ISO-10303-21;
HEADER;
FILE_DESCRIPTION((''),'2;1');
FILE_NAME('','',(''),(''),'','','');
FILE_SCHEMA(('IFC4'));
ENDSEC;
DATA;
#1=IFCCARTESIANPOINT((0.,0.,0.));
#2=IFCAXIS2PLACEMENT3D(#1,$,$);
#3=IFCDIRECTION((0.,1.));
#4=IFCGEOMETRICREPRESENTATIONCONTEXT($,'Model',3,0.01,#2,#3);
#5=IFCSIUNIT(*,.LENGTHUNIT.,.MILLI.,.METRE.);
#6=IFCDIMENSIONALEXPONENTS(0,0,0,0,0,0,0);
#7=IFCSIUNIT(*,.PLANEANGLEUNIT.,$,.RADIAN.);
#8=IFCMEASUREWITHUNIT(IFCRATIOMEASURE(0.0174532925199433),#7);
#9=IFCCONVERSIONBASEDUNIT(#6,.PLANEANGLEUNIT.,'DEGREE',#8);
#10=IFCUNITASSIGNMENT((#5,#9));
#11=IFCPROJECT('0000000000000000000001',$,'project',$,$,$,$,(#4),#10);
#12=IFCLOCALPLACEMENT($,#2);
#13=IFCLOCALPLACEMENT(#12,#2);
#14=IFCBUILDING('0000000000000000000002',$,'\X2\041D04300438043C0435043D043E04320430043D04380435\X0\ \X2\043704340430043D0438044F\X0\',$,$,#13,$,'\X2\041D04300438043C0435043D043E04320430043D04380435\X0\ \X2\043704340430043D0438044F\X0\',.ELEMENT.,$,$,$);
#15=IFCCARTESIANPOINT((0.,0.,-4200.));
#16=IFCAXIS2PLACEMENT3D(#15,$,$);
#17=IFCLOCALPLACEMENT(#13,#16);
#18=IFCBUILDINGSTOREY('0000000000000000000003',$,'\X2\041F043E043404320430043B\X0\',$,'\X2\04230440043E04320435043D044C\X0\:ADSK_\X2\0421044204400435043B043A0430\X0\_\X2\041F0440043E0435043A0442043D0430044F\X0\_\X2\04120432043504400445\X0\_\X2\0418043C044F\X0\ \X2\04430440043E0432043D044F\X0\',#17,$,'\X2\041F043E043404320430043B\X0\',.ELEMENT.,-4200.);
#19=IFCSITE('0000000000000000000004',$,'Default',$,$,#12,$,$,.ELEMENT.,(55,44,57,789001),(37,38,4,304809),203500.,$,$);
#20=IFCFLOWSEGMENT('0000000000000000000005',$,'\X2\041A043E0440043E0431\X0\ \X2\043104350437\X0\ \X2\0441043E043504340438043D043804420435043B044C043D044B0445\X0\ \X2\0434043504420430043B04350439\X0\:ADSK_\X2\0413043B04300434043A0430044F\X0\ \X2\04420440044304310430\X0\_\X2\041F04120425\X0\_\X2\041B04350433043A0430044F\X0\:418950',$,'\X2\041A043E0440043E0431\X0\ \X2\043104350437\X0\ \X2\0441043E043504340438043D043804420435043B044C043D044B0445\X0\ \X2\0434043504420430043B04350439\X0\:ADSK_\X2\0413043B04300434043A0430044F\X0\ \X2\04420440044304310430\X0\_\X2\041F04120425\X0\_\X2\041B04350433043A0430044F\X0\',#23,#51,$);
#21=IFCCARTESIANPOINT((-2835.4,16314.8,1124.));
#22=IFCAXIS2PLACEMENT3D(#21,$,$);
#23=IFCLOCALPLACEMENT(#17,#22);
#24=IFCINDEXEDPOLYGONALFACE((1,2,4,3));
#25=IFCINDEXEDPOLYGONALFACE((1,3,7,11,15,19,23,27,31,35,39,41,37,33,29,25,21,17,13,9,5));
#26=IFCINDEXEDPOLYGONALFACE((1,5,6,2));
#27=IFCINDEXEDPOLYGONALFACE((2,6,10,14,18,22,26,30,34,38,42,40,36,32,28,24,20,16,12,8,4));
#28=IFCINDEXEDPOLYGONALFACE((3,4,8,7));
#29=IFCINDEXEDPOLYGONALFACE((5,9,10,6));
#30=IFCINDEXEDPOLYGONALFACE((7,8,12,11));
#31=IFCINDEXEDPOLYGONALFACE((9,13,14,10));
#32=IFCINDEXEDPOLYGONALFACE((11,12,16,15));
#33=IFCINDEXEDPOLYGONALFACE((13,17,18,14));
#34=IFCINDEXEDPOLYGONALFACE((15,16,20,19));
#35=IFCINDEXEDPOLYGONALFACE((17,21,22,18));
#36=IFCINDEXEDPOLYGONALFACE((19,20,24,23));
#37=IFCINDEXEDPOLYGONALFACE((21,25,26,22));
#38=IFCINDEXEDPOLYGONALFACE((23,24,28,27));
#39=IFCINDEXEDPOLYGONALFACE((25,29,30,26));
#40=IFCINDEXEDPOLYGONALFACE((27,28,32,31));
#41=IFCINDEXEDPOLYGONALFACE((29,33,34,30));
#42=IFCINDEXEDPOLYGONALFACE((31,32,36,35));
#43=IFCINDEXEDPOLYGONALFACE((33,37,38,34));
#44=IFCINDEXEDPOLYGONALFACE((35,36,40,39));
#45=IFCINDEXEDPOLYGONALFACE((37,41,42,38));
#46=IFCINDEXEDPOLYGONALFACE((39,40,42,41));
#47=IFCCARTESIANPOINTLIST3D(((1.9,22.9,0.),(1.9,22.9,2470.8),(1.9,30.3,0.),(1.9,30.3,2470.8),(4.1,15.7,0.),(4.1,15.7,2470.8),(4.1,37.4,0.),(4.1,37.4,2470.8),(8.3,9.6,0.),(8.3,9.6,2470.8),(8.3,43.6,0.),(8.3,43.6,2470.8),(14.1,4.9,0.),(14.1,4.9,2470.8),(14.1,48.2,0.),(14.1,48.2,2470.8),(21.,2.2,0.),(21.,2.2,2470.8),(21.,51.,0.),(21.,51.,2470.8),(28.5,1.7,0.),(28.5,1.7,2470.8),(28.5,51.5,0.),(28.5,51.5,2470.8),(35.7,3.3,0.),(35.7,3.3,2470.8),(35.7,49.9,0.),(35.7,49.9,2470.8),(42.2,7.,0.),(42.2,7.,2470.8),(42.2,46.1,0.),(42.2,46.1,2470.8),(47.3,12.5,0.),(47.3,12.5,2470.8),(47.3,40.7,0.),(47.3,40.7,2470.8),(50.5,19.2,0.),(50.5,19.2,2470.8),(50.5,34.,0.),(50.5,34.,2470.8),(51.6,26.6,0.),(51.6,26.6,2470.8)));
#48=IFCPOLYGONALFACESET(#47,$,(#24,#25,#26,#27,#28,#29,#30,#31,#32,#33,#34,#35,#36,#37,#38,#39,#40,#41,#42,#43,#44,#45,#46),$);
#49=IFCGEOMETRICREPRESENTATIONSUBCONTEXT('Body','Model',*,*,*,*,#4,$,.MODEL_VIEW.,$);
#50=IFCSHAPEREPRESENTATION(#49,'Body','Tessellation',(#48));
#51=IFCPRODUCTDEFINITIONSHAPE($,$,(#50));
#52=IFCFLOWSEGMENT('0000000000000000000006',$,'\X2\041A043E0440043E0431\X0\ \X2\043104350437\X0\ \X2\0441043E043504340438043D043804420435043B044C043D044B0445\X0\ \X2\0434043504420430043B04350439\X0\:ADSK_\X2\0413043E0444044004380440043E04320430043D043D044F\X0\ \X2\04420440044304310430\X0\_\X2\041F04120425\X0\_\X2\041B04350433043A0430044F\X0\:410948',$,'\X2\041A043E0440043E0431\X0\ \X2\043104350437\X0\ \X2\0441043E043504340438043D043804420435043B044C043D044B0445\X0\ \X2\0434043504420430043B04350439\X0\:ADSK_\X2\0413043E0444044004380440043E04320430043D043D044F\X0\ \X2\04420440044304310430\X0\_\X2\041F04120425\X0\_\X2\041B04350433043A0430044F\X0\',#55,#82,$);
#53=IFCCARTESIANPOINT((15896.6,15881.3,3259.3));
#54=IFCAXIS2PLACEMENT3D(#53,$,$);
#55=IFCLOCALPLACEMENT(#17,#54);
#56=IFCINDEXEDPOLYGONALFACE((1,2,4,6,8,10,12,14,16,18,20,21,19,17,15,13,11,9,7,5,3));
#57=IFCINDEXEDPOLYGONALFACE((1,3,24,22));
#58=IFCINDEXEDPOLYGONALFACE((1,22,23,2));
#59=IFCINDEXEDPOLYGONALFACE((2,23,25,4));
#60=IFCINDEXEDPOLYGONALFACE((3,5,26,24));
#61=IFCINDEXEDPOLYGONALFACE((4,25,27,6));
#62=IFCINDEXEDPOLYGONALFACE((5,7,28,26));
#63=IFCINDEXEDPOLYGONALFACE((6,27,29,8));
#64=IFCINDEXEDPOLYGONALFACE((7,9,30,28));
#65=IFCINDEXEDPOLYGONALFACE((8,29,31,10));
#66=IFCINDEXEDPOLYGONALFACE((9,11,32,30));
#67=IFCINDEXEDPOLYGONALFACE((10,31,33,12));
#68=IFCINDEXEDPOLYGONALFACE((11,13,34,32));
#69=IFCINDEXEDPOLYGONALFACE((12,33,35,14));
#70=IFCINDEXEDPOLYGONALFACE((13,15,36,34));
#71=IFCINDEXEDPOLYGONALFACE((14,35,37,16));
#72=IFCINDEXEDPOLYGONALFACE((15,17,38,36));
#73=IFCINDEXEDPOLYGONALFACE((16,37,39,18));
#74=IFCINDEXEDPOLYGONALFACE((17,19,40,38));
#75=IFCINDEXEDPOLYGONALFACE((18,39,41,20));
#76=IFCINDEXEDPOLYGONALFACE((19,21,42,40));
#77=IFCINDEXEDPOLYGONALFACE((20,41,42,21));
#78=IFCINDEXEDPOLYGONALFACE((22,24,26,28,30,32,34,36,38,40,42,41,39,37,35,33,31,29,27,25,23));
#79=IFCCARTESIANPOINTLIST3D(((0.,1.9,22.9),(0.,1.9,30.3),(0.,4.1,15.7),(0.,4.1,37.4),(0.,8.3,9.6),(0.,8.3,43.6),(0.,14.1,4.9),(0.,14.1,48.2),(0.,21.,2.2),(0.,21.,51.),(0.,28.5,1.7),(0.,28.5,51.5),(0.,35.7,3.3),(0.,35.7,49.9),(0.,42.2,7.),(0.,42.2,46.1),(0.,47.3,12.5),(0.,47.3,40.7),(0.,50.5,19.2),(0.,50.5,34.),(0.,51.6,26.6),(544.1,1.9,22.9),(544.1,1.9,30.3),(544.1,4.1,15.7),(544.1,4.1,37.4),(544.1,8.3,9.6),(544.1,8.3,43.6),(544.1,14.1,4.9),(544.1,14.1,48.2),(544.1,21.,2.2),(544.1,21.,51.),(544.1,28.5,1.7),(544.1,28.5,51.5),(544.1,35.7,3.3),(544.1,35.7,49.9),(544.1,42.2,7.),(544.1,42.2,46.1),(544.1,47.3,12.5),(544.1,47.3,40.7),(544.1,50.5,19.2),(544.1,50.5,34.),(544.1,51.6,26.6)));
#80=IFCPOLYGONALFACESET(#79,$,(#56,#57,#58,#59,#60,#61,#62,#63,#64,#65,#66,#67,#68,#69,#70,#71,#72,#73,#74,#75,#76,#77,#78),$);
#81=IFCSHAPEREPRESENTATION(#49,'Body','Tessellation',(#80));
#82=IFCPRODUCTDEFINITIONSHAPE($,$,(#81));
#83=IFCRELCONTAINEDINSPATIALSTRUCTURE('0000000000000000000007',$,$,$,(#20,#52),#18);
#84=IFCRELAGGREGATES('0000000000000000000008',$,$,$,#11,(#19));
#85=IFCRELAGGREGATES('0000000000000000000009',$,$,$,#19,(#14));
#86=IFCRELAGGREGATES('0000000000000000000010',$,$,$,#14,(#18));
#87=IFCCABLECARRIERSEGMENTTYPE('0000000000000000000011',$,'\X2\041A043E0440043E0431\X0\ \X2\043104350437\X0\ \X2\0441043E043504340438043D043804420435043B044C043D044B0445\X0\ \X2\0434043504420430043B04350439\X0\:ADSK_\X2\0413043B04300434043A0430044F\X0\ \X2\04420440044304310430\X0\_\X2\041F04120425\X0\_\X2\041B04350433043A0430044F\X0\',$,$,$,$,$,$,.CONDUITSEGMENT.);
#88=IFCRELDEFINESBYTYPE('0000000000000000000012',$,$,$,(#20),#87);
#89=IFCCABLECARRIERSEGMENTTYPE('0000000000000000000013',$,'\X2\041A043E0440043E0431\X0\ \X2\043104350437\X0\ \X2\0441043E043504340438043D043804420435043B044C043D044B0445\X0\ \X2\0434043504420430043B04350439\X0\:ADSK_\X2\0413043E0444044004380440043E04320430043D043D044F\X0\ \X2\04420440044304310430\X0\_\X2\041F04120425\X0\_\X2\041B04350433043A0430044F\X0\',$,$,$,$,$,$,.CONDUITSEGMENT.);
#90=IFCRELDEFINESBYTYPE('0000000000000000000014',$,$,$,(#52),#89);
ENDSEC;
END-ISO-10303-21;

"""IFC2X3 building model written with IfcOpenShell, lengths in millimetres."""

from ifc_helpers import new_model, entity, si_unit, converted_unit, direction, frame, frame_2d, origin, origin_2d_with_axis, place, context, subcontext, project, spatial, circle, extrude, type_object, element, save


model = new_model("IFC2X3")

# Units and contexts
model_context = context("Model", 3, precision=0.01, world=origin(), true_north=direction((0.0, 1.0)))
body_context = subcontext(model_context, "Body", "Model", "MODEL_VIEW")
ifc_project = project(units=[si_unit("LENGTHUNIT", "METRE", prefix="MILLI"), converted_unit("PLANEANGLEUNIT", "DEGREE", entity("IfcRatioMeasure", 0.0174532925199433), si_unit("PLANEANGLEUNIT", "RADIAN"), dimensions=[0, 0, 0, 0, 0, 0, 0])], contexts=[model_context])

# Site, building, storey
site_placement = place(None, frame((0.0, 0.0, 0.0)))
site = spatial("IfcSite", under=ifc_project, at=site_placement, Name="Default", CompositionType="ELEMENT", RefLatitude=(55, 44, 57, 789001), RefLongitude=(37, 38, 4, 304809), RefElevation=203500.0)
building_placement = place(site_placement, origin())
building = spatial("IfcBuilding", under=site, at=building_placement, Name="Наименование здания", LongName="Наименование здания", CompositionType="ELEMENT")
storey_placement = place(building_placement, frame((0.0, 0.0, -4200.0)))
storey = spatial("IfcBuildingStorey", under=building, at=storey_placement, Name="Подвал", ObjectType="Уровень:ADSK_Стрелка_Проектная_Вверх_Имя уровня", LongName="Подвал", CompositionType="ELEMENT", Elevation=-4200.0)

# Flow segments
cable_carrier_segment_type_1 = type_object("IfcCableCarrierSegmentType", Name="Короб без соединительных деталей:ADSK_Гладкая труба_ПВХ_Легкая", PredefinedType="CONDUITSEGMENT")
flow_segment_1_placement = place(storey_placement, frame((-2835.4, 16314.8, 1124.0)))
element("IfcFlowSegment", 1, at=flow_segment_1_placement, inside=storey, type_object=cable_carrier_segment_type_1, Name="Короб без соединительных деталей:ADSK_Гладкая труба_ПВХ_Легкая:418950", ObjectType="Короб без соединительных деталей:ADSK_Гладкая труба_ПВХ_Легкая", context=body_context, shape_type="SweptSolid", body=[
    extrude(circle(Radius=25.0, at=frame_2d((0.0, 0.0), x_axis=(1.0, 0.0))), frame((26.6, 26.6, 0.0)), (0.0, 0.0, 1.0), 2470.8),
])
cable_carrier_segment_type_2 = type_object("IfcCableCarrierSegmentType", Name="Короб без соединительных деталей:ADSK_Гофрировання труба_ПВХ_Легкая", PredefinedType="CONDUITSEGMENT")
flow_segment_2_placement = place(storey_placement, frame((15896.6, 15881.3, 3259.3)))
element("IfcFlowSegment", 2, at=flow_segment_2_placement, inside=storey, type_object=cable_carrier_segment_type_2, Name="Короб без соединительных деталей:ADSK_Гофрировання труба_ПВХ_Легкая:410948", ObjectType="Короб без соединительных деталей:ADSK_Гофрировання труба_ПВХ_Легкая", context=body_context, shape_type="SweptSolid", body=[
    extrude(circle(Radius=25.0, at=origin_2d_with_axis()), frame((0.0, 26.6, 26.6), z_axis=(1.0, 0.0, 0.0), x_axis=(0.0, 1.0, 0.0)), (0.0, 0.0, 1.0), 544.1),
])

save(model, "model.ifc")
